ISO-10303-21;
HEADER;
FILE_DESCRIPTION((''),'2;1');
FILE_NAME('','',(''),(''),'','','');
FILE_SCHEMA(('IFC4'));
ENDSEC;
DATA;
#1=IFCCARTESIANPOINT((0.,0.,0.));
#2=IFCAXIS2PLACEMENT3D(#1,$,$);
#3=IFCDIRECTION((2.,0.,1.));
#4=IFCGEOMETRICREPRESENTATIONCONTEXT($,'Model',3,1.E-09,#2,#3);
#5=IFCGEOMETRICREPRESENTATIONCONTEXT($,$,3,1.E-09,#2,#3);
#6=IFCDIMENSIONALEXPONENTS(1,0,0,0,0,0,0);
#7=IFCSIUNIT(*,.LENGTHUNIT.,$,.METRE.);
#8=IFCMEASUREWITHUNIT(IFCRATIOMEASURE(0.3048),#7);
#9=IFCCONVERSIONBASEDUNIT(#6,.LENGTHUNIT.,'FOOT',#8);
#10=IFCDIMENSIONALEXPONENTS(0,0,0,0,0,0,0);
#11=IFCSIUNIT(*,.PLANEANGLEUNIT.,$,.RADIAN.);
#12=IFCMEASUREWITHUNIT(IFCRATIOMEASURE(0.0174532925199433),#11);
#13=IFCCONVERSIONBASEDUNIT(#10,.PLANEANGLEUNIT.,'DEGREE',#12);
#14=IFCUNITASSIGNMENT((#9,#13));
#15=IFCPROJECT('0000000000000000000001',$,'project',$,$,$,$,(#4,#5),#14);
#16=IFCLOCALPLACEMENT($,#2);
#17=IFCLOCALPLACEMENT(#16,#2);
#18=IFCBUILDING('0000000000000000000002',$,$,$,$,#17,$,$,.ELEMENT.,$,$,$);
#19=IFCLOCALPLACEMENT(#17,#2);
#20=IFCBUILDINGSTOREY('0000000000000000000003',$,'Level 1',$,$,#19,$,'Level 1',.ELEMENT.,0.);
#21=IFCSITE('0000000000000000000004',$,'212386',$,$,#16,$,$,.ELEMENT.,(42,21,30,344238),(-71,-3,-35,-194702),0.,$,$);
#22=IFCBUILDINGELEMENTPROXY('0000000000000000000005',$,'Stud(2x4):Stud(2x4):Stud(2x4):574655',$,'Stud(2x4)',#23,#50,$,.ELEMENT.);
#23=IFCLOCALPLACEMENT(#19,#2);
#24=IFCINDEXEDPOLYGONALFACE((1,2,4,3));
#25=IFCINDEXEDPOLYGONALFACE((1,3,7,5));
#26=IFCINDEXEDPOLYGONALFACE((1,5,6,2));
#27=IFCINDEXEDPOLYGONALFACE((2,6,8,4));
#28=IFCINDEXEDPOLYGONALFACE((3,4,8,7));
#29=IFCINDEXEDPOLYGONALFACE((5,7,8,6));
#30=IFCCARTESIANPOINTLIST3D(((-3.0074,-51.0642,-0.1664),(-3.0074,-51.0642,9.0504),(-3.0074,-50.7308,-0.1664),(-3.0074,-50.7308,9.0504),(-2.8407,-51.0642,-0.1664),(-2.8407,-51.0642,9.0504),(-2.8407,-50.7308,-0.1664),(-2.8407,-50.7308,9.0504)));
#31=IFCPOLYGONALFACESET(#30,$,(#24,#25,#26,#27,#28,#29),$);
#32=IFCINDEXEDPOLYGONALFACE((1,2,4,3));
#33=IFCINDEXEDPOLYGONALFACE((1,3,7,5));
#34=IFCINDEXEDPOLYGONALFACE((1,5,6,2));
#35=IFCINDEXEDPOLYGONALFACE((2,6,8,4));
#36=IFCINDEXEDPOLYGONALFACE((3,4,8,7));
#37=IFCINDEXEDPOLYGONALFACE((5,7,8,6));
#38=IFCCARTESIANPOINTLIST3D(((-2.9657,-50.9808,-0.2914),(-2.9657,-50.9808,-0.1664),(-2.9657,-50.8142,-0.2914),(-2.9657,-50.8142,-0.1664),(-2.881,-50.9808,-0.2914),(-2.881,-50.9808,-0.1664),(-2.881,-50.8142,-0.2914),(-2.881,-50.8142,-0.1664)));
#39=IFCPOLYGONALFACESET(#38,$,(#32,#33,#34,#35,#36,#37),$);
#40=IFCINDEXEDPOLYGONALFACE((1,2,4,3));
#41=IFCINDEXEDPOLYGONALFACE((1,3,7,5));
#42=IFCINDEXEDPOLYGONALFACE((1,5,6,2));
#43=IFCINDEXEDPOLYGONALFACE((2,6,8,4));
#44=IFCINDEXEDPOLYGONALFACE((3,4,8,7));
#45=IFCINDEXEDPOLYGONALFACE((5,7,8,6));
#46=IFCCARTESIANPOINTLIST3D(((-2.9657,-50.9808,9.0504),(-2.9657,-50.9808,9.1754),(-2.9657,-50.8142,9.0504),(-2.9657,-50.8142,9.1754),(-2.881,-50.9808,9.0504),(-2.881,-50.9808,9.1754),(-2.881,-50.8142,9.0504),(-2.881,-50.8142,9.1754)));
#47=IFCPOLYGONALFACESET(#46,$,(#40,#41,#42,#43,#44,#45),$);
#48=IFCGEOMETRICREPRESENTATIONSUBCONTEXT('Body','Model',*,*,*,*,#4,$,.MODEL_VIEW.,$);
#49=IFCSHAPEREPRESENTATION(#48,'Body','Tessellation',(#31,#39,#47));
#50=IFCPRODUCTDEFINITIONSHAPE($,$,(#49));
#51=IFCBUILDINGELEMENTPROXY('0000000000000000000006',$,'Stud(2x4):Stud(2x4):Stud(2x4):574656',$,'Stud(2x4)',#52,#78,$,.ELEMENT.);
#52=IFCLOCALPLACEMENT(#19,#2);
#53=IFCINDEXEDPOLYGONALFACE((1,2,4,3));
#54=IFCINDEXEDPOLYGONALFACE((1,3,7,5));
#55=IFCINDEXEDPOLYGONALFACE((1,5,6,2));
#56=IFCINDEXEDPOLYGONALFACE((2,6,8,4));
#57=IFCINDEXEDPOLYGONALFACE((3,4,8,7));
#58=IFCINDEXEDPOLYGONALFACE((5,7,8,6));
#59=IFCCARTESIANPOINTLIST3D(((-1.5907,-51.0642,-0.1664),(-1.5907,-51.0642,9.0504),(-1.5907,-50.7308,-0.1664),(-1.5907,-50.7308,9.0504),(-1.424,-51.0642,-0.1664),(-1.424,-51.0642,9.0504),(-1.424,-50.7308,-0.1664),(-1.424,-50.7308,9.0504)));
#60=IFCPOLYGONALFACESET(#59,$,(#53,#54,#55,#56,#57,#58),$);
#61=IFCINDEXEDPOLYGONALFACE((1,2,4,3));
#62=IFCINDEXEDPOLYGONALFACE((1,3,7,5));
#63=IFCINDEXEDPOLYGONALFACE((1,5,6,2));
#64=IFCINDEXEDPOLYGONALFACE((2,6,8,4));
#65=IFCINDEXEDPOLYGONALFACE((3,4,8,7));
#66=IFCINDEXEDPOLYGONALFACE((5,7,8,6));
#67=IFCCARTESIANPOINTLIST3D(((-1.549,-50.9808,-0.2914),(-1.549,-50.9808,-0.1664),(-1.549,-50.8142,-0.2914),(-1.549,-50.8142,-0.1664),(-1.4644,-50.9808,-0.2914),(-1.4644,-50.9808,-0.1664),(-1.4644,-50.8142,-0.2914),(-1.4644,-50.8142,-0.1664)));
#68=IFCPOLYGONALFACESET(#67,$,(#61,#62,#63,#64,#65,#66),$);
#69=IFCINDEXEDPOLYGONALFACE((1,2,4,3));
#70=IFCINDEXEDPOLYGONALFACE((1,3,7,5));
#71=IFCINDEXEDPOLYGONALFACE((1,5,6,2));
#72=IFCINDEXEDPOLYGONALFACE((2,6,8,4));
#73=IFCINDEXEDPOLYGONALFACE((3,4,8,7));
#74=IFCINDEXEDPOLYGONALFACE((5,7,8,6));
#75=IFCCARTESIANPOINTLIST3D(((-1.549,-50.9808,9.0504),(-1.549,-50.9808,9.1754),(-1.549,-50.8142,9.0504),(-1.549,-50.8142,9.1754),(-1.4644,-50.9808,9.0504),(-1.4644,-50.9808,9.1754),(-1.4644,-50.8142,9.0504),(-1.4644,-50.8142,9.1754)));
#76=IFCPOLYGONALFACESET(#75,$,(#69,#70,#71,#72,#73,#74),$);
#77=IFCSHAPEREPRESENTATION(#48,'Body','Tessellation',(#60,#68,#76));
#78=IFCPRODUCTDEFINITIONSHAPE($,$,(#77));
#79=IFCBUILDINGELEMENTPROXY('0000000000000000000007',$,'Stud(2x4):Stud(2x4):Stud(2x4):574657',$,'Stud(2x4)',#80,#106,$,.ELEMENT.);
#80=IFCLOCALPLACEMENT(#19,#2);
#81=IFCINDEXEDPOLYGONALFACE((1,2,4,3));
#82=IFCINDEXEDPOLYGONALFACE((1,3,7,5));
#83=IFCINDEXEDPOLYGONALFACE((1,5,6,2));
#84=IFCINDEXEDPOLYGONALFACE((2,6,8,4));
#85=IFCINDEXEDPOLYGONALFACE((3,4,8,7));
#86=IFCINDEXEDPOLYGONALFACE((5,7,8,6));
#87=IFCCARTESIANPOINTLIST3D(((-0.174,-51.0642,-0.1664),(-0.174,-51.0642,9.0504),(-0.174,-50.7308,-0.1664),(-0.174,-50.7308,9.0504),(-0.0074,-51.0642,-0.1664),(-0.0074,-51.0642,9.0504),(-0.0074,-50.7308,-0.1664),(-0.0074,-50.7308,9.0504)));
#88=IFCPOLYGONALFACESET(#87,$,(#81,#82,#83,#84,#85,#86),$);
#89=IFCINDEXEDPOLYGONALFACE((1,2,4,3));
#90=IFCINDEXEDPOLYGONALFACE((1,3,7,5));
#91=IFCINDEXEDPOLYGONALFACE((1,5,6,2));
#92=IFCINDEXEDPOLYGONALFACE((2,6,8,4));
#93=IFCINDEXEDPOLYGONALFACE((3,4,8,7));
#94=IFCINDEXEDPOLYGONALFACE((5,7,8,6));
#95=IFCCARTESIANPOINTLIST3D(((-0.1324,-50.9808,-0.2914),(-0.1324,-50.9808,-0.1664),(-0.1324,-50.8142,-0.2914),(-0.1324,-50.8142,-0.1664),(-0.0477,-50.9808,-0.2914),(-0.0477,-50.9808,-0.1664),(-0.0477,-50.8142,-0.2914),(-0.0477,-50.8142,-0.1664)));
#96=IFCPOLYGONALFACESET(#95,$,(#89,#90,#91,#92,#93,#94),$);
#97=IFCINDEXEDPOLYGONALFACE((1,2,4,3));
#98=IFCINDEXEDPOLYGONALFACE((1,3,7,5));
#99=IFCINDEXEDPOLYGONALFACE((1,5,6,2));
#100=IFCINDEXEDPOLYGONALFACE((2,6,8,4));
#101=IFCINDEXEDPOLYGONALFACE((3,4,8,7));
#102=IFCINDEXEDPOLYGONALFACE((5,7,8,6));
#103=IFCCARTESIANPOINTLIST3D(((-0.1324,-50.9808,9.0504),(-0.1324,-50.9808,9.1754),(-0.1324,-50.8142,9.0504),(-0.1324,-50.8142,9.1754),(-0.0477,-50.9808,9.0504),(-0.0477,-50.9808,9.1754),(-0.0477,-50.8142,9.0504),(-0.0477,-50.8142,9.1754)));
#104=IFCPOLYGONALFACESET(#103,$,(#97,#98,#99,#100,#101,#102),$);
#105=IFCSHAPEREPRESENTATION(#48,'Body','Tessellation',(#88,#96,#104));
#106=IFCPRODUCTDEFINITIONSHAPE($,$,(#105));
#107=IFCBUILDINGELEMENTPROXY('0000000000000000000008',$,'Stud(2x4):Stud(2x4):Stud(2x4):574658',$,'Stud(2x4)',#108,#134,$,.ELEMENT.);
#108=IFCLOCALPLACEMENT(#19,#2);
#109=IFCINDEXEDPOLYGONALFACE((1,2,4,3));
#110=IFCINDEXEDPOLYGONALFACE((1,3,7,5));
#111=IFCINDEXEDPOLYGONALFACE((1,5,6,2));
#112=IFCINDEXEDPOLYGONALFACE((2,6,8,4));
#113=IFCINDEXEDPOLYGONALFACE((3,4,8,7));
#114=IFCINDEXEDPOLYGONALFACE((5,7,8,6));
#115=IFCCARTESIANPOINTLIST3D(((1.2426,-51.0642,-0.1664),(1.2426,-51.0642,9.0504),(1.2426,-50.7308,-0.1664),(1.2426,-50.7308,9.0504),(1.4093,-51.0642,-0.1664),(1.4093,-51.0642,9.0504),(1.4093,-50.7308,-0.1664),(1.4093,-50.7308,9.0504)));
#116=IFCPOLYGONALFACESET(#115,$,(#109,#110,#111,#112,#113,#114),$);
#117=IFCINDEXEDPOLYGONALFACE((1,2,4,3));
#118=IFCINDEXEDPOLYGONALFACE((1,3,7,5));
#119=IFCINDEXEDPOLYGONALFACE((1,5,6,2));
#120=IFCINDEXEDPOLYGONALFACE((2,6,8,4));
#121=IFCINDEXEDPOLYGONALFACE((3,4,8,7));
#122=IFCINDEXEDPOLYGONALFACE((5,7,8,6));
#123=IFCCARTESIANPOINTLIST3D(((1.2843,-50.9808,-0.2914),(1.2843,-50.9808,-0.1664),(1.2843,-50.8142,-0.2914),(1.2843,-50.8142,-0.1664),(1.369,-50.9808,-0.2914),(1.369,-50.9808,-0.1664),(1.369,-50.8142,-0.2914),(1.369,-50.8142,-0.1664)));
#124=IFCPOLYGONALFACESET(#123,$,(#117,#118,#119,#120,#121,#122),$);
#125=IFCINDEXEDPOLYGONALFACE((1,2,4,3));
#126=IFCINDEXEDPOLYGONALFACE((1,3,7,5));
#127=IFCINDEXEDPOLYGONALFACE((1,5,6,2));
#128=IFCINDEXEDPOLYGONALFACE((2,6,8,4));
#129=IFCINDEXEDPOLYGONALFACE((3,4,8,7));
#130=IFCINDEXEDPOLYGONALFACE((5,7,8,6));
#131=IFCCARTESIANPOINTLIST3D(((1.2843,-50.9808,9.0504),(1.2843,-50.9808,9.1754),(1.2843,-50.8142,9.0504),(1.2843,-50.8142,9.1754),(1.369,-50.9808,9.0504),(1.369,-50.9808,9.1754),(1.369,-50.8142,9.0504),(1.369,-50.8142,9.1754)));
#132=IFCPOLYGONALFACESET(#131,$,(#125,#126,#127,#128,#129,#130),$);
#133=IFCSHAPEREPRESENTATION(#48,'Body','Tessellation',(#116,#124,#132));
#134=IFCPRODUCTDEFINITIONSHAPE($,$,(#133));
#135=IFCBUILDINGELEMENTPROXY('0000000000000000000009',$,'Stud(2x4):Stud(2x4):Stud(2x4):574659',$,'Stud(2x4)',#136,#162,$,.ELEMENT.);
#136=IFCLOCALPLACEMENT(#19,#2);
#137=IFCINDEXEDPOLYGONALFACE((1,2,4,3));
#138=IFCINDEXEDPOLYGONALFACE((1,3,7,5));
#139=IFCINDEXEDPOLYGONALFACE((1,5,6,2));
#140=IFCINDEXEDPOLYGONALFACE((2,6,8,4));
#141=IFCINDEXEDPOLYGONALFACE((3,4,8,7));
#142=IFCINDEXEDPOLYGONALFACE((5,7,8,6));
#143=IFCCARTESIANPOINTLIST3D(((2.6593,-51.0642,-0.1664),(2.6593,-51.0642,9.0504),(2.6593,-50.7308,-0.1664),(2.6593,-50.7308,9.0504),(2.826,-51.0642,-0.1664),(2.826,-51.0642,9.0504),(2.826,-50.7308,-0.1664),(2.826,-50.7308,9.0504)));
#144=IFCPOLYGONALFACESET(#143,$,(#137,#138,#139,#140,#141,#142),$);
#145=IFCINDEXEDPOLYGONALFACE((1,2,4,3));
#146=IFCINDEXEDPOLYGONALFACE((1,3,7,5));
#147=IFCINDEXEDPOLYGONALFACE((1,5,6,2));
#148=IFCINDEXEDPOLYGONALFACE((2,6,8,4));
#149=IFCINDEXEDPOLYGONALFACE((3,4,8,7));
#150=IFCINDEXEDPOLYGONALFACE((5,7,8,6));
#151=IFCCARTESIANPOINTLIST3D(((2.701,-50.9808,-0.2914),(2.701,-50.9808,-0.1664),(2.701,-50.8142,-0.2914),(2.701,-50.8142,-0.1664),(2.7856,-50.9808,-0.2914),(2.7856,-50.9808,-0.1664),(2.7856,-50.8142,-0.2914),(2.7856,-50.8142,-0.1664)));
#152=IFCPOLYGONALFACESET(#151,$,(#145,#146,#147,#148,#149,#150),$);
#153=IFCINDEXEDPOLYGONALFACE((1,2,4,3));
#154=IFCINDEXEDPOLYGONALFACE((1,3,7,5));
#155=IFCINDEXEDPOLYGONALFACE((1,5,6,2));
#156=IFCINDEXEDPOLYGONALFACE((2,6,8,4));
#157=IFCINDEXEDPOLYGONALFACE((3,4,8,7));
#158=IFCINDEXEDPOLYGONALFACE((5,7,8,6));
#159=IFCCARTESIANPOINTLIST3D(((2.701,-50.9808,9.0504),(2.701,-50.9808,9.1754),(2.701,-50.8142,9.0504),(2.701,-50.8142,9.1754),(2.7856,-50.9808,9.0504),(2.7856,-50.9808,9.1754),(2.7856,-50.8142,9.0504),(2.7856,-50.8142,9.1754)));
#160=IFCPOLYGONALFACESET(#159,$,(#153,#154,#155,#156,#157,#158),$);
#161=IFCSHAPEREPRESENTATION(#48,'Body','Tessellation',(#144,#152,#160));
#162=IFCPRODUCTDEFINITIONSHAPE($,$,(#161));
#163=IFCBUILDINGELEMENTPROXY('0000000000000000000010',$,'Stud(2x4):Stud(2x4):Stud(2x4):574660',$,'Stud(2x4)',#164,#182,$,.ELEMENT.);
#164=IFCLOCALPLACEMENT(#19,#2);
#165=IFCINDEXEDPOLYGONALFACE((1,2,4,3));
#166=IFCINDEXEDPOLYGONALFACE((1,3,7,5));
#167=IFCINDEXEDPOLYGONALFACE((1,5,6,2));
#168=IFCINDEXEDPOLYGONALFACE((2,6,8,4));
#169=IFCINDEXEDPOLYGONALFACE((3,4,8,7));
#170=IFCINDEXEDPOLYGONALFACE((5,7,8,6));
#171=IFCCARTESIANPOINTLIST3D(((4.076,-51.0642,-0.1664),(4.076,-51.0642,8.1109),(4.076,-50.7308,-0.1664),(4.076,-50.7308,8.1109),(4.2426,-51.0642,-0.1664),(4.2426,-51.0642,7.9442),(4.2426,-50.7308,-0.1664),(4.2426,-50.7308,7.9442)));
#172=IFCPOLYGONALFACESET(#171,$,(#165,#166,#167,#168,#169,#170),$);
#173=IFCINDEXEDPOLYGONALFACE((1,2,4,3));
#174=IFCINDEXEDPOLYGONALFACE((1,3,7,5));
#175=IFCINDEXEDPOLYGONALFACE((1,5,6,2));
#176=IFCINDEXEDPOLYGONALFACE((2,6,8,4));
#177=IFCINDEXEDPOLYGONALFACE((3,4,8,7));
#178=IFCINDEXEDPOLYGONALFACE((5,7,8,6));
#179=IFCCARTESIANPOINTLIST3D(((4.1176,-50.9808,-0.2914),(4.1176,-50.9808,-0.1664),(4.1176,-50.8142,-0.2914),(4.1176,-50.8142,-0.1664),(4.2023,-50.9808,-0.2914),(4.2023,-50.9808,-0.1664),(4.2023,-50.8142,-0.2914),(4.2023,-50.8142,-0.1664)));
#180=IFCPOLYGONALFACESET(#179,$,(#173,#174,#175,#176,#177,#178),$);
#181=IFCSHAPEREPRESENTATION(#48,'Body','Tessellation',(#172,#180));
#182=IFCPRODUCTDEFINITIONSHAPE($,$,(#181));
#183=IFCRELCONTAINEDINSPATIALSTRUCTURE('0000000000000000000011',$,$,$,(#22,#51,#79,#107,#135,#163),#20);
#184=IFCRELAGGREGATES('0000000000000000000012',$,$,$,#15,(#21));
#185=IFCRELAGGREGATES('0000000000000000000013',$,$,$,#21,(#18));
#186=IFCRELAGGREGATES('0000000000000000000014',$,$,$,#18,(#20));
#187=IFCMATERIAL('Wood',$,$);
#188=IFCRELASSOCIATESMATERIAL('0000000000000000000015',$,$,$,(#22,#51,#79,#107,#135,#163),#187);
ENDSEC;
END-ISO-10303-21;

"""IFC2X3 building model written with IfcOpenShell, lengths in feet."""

from ifc_helpers import new_model, entity, si_unit, converted_unit, direction, frame, frame_2d, origin, place, context, subcontext, project, spatial, polyline, rectangle, outline, extrude, source, transform, mapped, material, element, save


model = new_model("IFC2X3")

# Units and contexts
model_context = context("Model", 3, precision=1e-09, world=origin(), true_north=direction((2.0, 0.0, 1.0)))
context_of_model = context(None, 3, precision=1e-09, world=origin(), true_north=direction((2.0, 0.0, 1.0)))
body_context = subcontext(model_context, "Body", "Model", "MODEL_VIEW")
ifc_project = project(units=[converted_unit("LENGTHUNIT", "FOOT", entity("IfcRatioMeasure", 0.3048), si_unit("LENGTHUNIT", "METRE"), dimensions=[1, 0, 0, 0, 0, 0, 0]), converted_unit("PLANEANGLEUNIT", "DEGREE", entity("IfcRatioMeasure", 0.0174532925199433), si_unit("PLANEANGLEUNIT", "RADIAN"), dimensions=[0, 0, 0, 0, 0, 0, 0])], contexts=[model_context, context_of_model])

# Site, building, storey
site_placement = place(None, origin())
site = spatial("IfcSite", under=ifc_project, at=site_placement, Name="212386", CompositionType="ELEMENT", RefLatitude=(42, 21, 30, 344238), RefLongitude=(-71, -3, -35, -194702), RefElevation=0.0)
building_placement = place(site_placement, origin())
building = spatial("IfcBuilding", under=site, at=building_placement, CompositionType="ELEMENT")
storey_placement = place(building_placement, origin())
storey = spatial("IfcBuildingStorey", under=building, at=storey_placement, Name="Level 1", LongName="Level 1", CompositionType="ELEMENT", Elevation=0.0)

# Building element proxies
ifc_material = material(Name="Wood")
shared_shape_1 = source(origin(), body_context, "Body", "SweptSolid", [
    extrude(rectangle(XDim=0.3333, YDim=0.1667, at=frame_2d((0.0, 0.0), x_axis=(1.0, 0.0))), frame((-2.924, -50.8975, -0.1664), z_axis=(0.0, 0.0, 1.0), x_axis=(0.0, -1.0, 0.0)), (0.0, 0.0, 1.0), 9.2168),
    extrude(rectangle(XDim=0.1667, YDim=0.0847, at=frame_2d((0.0, 0.0), x_axis=(1.0, 0.0))), frame((-2.9234, -50.8975, -0.2914), z_axis=(0.0, 0.0, 1.0), x_axis=(0.0, -1.0, 0.0)), (0.0, 0.0, 1.0), 0.125),
    extrude(rectangle(XDim=0.0847, YDim=0.1667, at=frame_2d((0.0, 0.0), x_axis=(1.0, 0.0))), frame((-2.9234, -50.8975, 9.0504)), (0.0, 0.0, 1.0), 0.125),
])
proxy_1_placement = place(storey_placement, origin())
element("IfcBuildingElementProxy", 1, at=proxy_1_placement, inside=storey, material=ifc_material, Name="Stud(2x4):Stud(2x4):Stud(2x4):574655", ObjectType="Stud(2x4)", CompositionType="ELEMENT", context=body_context, shape_type="MappedRepresentation", body=[
    mapped(shared_shape_1, transform((0.0, 0.0, 0.0), scale=1.0)),
])
shared_shape_2 = source(origin(), body_context, "Body", "SweptSolid", [
    extrude(rectangle(XDim=0.3333, YDim=0.1667, at=frame_2d((0.0, 0.0), x_axis=(1.0, 0.0))), frame((-1.5074, -50.8975, -0.1664), z_axis=(0.0, 0.0, 1.0), x_axis=(0.0, -1.0, 0.0)), (0.0, 0.0, 1.0), 9.2168),
    extrude(rectangle(XDim=0.1667, YDim=0.0847, at=frame_2d((0.0, 0.0), x_axis=(1.0, 0.0))), frame((-1.5067, -50.8975, -0.2914), z_axis=(0.0, 0.0, 1.0), x_axis=(0.0, -1.0, 0.0)), (0.0, 0.0, 1.0), 0.125),
    extrude(rectangle(XDim=0.0847, YDim=0.1667, at=frame_2d((0.0, 0.0), x_axis=(1.0, 0.0))), frame((-1.5067, -50.8975, 9.0504)), (0.0, 0.0, 1.0), 0.125),
])
proxy_2_placement = place(storey_placement, origin())
element("IfcBuildingElementProxy", 2, at=proxy_2_placement, inside=storey, material=ifc_material, Name="Stud(2x4):Stud(2x4):Stud(2x4):574656", ObjectType="Stud(2x4)", CompositionType="ELEMENT", context=body_context, shape_type="MappedRepresentation", body=[
    mapped(shared_shape_2, transform((0.0, 0.0, 0.0), scale=1.0)),
])
shared_shape_3 = source(origin(), body_context, "Body", "SweptSolid", [
    extrude(rectangle(XDim=0.3333, YDim=0.1667, at=frame_2d((0.0, 0.0), x_axis=(1.0, 0.0))), frame((-0.0907, -50.8975, -0.1664), z_axis=(0.0, 0.0, 1.0), x_axis=(0.0, -1.0, 0.0)), (0.0, 0.0, 1.0), 9.2168),
    extrude(rectangle(XDim=0.1667, YDim=0.0847, at=frame_2d((0.0, 0.0), x_axis=(1.0, 0.0))), frame((-0.09, -50.8975, -0.2914), z_axis=(0.0, 0.0, 1.0), x_axis=(0.0, -1.0, 0.0)), (0.0, 0.0, 1.0), 0.125),
    extrude(rectangle(XDim=0.0847, YDim=0.1667, at=frame_2d((0.0, 0.0), x_axis=(1.0, 0.0))), frame((-0.09, -50.8975, 9.0504)), (0.0, 0.0, 1.0), 0.125),
])
proxy_3_placement = place(storey_placement, origin())
element("IfcBuildingElementProxy", 3, at=proxy_3_placement, inside=storey, material=ifc_material, Name="Stud(2x4):Stud(2x4):Stud(2x4):574657", ObjectType="Stud(2x4)", CompositionType="ELEMENT", context=body_context, shape_type="MappedRepresentation", body=[
    mapped(shared_shape_3, transform((0.0, 0.0, 0.0), scale=1.0)),
])
shared_shape_4 = source(origin(), body_context, "Body", "SweptSolid", [
    extrude(rectangle(XDim=0.3333, YDim=0.1667, at=frame_2d((0.0, 0.0), x_axis=(1.0, 0.0))), frame((1.326, -50.8975, -0.1664), z_axis=(0.0, 0.0, 1.0), x_axis=(0.0, -1.0, 0.0)), (0.0, 0.0, 1.0), 9.2168),
    extrude(rectangle(XDim=0.1667, YDim=0.0847, at=frame_2d((0.0, 0.0), x_axis=(1.0, 0.0))), frame((1.3266, -50.8975, -0.2914), z_axis=(0.0, 0.0, 1.0), x_axis=(0.0, -1.0, 0.0)), (0.0, 0.0, 1.0), 0.125),
    extrude(rectangle(XDim=0.0847, YDim=0.1667, at=frame_2d((0.0, 0.0), x_axis=(1.0, 0.0))), frame((1.3266, -50.8975, 9.0504)), (0.0, 0.0, 1.0), 0.125),
])
proxy_4_placement = place(storey_placement, origin())
element("IfcBuildingElementProxy", 4, at=proxy_4_placement, inside=storey, material=ifc_material, Name="Stud(2x4):Stud(2x4):Stud(2x4):574658", ObjectType="Stud(2x4)", CompositionType="ELEMENT", context=body_context, shape_type="MappedRepresentation", body=[
    mapped(shared_shape_4, transform((0.0, 0.0, 0.0), scale=1.0)),
])
shared_shape_5 = source(origin(), body_context, "Body", "SweptSolid", [
    extrude(rectangle(XDim=0.3333, YDim=0.1667, at=frame_2d((0.0, 0.0), x_axis=(1.0, 0.0))), frame((2.7426, -50.8975, -0.1664), z_axis=(0.0, 0.0, 1.0), x_axis=(0.0, -1.0, 0.0)), (0.0, 0.0, 1.0), 9.2168),
    extrude(rectangle(XDim=0.1667, YDim=0.0847, at=frame_2d((0.0, 0.0), x_axis=(1.0, 0.0))), frame((2.7433, -50.8975, -0.2914), z_axis=(0.0, 0.0, 1.0), x_axis=(0.0, -1.0, 0.0)), (0.0, 0.0, 1.0), 0.125),
    extrude(rectangle(XDim=0.0847, YDim=0.1667, at=frame_2d((0.0, 0.0), x_axis=(1.0, 0.0))), frame((2.7433, -50.8975, 9.0504)), (0.0, 0.0, 1.0), 0.125),
])
proxy_5_placement = place(storey_placement, origin())
element("IfcBuildingElementProxy", 5, at=proxy_5_placement, inside=storey, material=ifc_material, Name="Stud(2x4):Stud(2x4):Stud(2x4):574659", ObjectType="Stud(2x4)", CompositionType="ELEMENT", context=body_context, shape_type="MappedRepresentation", body=[
    mapped(shared_shape_5, transform((0.0, 0.0, 0.0), scale=1.0)),
])
shared_shape_6 = source(origin(), body_context, "Body", "SweptSolid", [
    extrude(outline(polyline([(-4.097, -0.0833), (4.1803, -0.0833), (4.0136, 0.0833), (-4.097, 0.0833), (-4.097, -0.0833)])), frame((4.1593, -51.0642, 3.9306), z_axis=(0.0, 1.0, 0.0), x_axis=(0.0, 0.0, 1.0)), (0.0, 0.0, 1.0), 0.3333),
    extrude(rectangle(XDim=0.1667, YDim=0.0847, at=frame_2d((0.0, 0.0), x_axis=(1.0, 0.0))), frame((4.16, -50.8975, -0.2914), z_axis=(0.0, 0.0, 1.0), x_axis=(0.0, -1.0, 0.0)), (0.0, 0.0, 1.0), 0.125),
])
proxy_6_placement = place(storey_placement, origin())
element("IfcBuildingElementProxy", 6, at=proxy_6_placement, inside=storey, material=ifc_material, Name="Stud(2x4):Stud(2x4):Stud(2x4):574660", ObjectType="Stud(2x4)", CompositionType="ELEMENT", context=body_context, shape_type="MappedRepresentation", body=[
    mapped(shared_shape_6, transform((0.0, 0.0, 0.0), scale=1.0)),
])

save(model, "model.ifc")
